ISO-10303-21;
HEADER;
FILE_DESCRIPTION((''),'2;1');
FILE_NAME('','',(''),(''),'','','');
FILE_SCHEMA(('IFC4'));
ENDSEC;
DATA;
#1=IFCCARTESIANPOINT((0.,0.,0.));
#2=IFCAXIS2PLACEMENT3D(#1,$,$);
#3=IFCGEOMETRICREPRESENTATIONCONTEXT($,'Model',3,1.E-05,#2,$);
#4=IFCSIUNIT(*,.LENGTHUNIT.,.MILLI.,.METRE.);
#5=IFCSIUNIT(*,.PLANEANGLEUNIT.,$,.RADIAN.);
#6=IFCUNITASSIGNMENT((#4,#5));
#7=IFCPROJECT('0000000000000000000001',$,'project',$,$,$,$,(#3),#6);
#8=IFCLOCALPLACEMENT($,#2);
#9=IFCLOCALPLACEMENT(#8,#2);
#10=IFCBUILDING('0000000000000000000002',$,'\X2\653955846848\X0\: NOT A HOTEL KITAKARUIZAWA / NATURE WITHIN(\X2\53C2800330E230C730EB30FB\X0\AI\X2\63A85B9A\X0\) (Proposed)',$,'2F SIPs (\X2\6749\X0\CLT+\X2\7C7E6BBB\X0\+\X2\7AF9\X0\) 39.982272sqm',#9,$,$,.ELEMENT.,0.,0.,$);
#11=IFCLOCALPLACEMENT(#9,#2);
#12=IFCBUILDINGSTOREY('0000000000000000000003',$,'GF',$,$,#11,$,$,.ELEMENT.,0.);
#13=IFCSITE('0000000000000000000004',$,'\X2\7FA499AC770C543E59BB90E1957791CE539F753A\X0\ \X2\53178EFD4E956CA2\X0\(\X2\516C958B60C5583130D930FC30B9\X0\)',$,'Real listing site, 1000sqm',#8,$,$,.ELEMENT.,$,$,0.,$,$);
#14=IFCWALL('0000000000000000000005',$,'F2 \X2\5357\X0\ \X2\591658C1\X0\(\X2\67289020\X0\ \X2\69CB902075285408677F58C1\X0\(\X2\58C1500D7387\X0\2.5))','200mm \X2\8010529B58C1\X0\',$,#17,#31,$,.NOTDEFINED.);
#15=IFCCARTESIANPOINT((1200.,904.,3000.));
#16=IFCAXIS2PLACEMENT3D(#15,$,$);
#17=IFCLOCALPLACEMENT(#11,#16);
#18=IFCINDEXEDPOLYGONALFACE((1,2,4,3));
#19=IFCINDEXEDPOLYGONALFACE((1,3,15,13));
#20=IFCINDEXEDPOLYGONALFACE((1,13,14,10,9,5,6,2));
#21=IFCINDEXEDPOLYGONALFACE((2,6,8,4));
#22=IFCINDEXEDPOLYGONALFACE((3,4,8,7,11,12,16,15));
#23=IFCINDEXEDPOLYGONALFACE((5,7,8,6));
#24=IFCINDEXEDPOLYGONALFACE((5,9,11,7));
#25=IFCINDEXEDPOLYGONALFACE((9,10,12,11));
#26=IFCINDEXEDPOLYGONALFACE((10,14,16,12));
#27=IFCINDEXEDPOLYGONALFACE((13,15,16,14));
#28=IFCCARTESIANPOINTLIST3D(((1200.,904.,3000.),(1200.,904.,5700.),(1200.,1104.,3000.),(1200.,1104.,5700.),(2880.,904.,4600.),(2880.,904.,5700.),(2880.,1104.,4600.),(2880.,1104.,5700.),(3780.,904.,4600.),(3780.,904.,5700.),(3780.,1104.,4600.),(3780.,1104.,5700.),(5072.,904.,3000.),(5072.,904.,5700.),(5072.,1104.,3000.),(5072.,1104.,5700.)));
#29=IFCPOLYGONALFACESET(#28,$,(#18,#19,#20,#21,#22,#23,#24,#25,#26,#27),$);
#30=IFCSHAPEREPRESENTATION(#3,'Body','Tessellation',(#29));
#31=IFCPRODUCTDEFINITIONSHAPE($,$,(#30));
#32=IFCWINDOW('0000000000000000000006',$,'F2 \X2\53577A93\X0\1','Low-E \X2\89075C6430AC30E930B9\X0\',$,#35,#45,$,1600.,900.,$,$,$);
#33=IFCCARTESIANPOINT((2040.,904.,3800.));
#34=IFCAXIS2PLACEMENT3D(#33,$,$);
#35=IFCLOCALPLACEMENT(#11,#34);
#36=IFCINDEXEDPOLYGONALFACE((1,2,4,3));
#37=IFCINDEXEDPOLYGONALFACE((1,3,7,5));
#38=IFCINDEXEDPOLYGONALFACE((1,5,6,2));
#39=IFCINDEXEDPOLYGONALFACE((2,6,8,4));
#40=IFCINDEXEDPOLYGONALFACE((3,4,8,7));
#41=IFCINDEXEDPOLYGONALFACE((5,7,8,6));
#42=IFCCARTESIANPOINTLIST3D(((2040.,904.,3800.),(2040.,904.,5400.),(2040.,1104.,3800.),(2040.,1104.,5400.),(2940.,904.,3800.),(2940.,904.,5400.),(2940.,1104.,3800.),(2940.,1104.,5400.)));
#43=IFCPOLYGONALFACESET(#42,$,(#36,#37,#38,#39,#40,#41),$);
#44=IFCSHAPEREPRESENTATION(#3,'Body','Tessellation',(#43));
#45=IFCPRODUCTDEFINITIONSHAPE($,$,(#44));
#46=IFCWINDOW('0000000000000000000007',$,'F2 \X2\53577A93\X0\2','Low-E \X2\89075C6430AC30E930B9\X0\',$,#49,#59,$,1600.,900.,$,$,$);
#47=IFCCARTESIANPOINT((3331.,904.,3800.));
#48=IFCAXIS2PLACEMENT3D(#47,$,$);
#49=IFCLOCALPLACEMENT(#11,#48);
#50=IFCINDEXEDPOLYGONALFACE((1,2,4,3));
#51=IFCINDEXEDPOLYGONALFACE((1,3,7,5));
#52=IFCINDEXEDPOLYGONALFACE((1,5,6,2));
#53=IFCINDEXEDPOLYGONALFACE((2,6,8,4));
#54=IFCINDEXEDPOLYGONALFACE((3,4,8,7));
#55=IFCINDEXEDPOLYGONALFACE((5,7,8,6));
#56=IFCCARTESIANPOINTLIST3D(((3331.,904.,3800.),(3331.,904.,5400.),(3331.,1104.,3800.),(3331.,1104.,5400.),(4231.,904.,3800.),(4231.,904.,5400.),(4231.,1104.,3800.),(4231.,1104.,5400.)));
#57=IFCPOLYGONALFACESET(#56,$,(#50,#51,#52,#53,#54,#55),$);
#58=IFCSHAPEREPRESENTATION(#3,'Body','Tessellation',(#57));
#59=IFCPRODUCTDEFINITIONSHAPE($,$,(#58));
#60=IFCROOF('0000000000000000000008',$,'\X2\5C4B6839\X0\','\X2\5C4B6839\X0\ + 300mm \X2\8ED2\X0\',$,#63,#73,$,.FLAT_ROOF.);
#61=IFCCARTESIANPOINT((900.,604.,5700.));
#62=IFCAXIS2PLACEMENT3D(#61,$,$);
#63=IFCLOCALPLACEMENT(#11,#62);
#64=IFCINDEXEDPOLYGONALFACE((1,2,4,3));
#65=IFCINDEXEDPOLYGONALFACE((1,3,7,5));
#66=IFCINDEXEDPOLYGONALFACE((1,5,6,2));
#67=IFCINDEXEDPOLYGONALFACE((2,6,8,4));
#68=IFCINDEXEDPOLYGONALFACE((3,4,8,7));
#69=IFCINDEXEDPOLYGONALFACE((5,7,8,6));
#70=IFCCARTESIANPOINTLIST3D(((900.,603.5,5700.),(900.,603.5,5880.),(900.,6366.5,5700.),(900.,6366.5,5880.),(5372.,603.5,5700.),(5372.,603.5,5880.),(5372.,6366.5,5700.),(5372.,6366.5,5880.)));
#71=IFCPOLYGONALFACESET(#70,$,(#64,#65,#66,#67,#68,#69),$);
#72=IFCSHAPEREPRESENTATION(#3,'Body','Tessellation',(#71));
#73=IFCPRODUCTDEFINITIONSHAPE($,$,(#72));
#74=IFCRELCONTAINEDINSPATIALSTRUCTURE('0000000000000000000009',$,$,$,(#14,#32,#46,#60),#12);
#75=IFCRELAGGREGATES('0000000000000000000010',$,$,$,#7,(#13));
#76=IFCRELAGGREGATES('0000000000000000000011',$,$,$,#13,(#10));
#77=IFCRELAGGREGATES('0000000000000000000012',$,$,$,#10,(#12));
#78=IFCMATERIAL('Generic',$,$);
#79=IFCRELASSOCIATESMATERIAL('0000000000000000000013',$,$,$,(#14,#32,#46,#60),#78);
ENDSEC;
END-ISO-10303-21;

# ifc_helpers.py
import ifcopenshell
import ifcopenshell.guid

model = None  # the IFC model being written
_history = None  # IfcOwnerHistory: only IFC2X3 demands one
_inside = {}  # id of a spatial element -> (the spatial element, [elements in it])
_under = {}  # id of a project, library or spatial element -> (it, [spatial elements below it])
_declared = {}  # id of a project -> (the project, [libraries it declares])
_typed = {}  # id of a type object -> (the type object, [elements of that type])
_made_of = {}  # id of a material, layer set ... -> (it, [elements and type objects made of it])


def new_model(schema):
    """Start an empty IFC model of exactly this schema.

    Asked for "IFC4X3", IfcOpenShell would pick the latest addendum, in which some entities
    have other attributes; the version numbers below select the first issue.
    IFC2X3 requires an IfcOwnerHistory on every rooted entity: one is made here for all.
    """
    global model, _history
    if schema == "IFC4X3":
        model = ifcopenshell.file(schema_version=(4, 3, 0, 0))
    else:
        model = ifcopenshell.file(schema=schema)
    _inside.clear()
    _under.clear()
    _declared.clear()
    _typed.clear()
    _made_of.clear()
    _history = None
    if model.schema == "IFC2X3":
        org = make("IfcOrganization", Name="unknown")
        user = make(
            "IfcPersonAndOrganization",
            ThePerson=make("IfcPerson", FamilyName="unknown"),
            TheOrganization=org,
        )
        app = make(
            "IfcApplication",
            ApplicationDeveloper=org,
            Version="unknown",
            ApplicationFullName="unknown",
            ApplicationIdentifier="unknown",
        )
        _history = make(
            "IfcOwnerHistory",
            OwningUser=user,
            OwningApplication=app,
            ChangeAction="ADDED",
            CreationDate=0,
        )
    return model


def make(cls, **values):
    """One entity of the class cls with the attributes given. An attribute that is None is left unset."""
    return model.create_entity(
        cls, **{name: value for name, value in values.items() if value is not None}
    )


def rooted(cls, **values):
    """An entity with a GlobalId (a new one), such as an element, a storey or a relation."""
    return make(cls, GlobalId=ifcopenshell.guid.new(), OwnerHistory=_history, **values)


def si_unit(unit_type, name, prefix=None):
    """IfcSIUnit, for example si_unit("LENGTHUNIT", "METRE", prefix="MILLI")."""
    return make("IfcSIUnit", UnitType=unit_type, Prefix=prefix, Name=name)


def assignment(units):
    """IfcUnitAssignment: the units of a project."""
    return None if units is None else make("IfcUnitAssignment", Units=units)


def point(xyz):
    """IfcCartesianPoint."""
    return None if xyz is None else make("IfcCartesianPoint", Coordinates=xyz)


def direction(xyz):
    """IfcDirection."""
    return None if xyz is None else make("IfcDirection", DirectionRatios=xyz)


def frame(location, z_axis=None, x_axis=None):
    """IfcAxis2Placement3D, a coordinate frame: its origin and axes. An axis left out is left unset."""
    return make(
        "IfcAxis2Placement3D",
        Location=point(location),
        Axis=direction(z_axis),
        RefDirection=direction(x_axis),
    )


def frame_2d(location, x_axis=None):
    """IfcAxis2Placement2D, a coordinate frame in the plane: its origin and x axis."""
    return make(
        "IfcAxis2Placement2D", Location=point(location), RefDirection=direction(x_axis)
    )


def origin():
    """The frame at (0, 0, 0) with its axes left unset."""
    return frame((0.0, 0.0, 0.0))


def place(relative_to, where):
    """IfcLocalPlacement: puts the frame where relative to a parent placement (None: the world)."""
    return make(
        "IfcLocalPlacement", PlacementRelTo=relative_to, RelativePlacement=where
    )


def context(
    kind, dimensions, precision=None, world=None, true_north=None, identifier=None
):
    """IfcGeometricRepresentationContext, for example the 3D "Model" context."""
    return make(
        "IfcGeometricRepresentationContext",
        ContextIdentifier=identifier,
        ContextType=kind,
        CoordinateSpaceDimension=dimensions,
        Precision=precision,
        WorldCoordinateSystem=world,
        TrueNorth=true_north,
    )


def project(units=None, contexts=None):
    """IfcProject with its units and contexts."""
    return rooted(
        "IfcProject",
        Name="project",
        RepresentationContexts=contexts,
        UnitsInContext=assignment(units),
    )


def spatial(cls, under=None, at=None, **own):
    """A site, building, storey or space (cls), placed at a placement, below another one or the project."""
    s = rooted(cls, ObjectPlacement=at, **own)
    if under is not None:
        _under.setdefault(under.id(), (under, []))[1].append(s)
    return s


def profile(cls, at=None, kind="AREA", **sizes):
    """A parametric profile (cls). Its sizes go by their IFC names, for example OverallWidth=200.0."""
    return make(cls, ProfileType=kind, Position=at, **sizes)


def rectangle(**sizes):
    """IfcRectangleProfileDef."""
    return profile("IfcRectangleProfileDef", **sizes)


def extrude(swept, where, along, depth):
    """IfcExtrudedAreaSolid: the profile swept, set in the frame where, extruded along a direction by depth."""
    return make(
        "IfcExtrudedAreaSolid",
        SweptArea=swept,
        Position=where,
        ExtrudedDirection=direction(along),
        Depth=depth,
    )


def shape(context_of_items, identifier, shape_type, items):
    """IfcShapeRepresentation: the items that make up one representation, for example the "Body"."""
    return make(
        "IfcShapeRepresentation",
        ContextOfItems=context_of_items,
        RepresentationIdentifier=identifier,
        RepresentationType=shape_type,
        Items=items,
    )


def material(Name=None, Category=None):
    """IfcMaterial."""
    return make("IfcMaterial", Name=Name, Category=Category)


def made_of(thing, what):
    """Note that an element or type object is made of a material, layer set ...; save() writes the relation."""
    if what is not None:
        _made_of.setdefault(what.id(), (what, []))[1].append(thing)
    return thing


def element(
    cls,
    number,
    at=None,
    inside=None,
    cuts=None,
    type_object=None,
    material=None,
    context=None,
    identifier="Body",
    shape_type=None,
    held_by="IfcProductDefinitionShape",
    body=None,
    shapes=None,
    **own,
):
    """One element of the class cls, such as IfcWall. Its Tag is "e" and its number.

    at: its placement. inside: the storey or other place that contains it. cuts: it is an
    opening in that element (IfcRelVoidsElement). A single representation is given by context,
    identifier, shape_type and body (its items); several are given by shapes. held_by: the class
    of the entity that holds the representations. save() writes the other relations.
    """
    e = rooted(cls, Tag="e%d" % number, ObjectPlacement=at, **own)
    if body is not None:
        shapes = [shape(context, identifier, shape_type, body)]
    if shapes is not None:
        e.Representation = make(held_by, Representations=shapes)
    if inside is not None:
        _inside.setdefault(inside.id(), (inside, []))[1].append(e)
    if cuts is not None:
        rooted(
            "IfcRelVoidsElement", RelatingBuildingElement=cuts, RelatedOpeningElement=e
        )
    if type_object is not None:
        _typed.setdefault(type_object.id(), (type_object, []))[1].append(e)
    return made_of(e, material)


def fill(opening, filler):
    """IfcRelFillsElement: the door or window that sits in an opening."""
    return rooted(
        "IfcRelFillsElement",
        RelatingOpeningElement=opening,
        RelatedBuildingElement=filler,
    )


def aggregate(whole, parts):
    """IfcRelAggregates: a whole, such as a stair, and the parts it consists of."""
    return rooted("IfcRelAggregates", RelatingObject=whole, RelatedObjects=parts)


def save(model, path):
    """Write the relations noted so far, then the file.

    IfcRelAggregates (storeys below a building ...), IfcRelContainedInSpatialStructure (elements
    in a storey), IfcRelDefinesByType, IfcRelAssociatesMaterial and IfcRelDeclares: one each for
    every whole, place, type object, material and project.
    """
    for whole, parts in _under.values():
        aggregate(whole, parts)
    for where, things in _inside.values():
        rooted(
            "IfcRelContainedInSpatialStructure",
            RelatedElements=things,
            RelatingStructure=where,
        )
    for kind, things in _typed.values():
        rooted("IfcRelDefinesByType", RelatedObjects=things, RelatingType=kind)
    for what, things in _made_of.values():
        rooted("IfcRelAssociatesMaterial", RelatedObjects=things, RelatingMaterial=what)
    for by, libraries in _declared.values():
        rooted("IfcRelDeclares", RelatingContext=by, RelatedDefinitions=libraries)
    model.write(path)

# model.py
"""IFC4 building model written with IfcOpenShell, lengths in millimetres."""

from ifc_helpers import new_model, si_unit, frame, frame_2d, origin, place, context, project, spatial, rectangle, extrude, material, element, fill, save


model = new_model("IFC4")

# Units and contexts
model_context = context("Model", 3, precision=1e-05, world=origin())
ifc_project = project(units=[si_unit("LENGTHUNIT", "METRE", prefix="MILLI"), si_unit("PLANEANGLEUNIT", "RADIAN")], contexts=[model_context])

# Site, building, storey
site_placement = place(None, origin())
site = spatial("IfcSite", under=ifc_project, at=site_placement, Name="群馬県吾妻郡長野原町 北軽井沢(公開情報ベース)", ObjectType="Real listing site, 1000sqm", CompositionType="ELEMENT", RefElevation=0.0)
building_placement = place(site_placement, origin())
building = spatial("IfcBuilding", under=site, at=building_placement, Name="改善案: NOT A HOTEL KITAKARUIZAWA / NATURE WITHIN(参考モデル・AI推定) (Proposed)", ObjectType="2F SIPs (杉CLT+籾殻+竹) 39.982272sqm", CompositionType="ELEMENT", ElevationOfRefHeight=0.0, ElevationOfTerrain=0.0)
storey_placement = place(building_placement, origin())
storey = spatial("IfcBuildingStorey", under=building, at=storey_placement, Name="GF", CompositionType="ELEMENT", Elevation=0.0)

# Shared definitions
ifc_material_1 = material(Name="Generic")

# Wall, openings, windows
wall_1_placement = place(storey_placement, frame((1200.0, 904.0, 3000.0)))
wall_1 = element("IfcWall", 1, at=wall_1_placement, inside=storey, material=ifc_material_1, Name="F2 南 外壁(木造 構造用合板壁(壁倍率2.5))", Description="200mm 耐力壁", PredefinedType="NOTDEFINED", context=model_context, shape_type="SweptSolid", body=[
    extrude(rectangle(XDim=3872.0, YDim=200.0, at=frame_2d((1936.0, 100.0))), frame((1200.0, 904.0, 3000.0)), (0.0, 0.0, 1.0), 2700.0),
])
opening_1_placement = place(storey_placement, frame((2040.0, 904.0, 3800.0)))
opening_1 = element("IfcOpeningElement", 2, at=opening_1_placement, cuts=wall_1, PredefinedType="NOTDEFINED", context=model_context, shape_type="SweptSolid", body=[
    extrude(rectangle(XDim=900.0, YDim=200.0, at=frame_2d((450.0, 100.0))), frame((2040.0, 904.0, 3800.0)), (0.0, 0.0, 1.0), 1600.0),
])
opening_2_placement = place(storey_placement, frame((3331.0, 904.0, 3800.0)))
opening_2 = element("IfcOpeningElement", 3, at=opening_2_placement, cuts=wall_1, PredefinedType="NOTDEFINED", context=model_context, shape_type="SweptSolid", body=[
    extrude(rectangle(XDim=900.0, YDim=200.0, at=frame_2d((450.0, 100.0))), frame((3331.0, 904.0, 3800.0)), (0.0, 0.0, 1.0), 1600.0),
])
window_1_placement = place(storey_placement, frame((2040.0, 904.0, 3800.0)))
window_1 = element("IfcWindow", 4, at=window_1_placement, inside=storey, material=ifc_material_1, Name="F2 南窓1", Description="Low-E 複層ガラス", OverallHeight=1600.0, OverallWidth=900.0, context=model_context, shape_type="SweptSolid", body=[
    extrude(rectangle(XDim=900.0, YDim=200.0, at=frame_2d((450.0, 100.0))), frame((2040.0, 904.0, 3800.0)), (0.0, 0.0, 1.0), 1600.0),
])
fill(opening_1, window_1)
window_2_placement = place(storey_placement, frame((3331.0, 904.0, 3800.0)))
window_2 = element("IfcWindow", 5, at=window_2_placement, inside=storey, material=ifc_material_1, Name="F2 南窓2", Description="Low-E 複層ガラス", OverallHeight=1600.0, OverallWidth=900.0, context=model_context, shape_type="SweptSolid", body=[
    extrude(rectangle(XDim=900.0, YDim=200.0, at=frame_2d((450.0, 100.0))), frame((3331.0, 904.0, 3800.0)), (0.0, 0.0, 1.0), 1600.0),
])
fill(opening_2, window_2)

# Roof
roof_placement = place(storey_placement, frame((900.0, 604.0, 5700.0)))
element("IfcRoof", 6, at=roof_placement, inside=storey, material=ifc_material_1, Name="屋根", Description="屋根 + 300mm 軒", PredefinedType="FLAT_ROOF", context=model_context, shape_type="SweptSolid", body=[
    extrude(rectangle(XDim=4472.0, YDim=5763.0, at=frame_2d((2236.0, 2881.0))), frame((900.0, 604.0, 5700.0)), (0.0, 0.0, 1.0), 180.0),
])

save(model, "model.ifc")
